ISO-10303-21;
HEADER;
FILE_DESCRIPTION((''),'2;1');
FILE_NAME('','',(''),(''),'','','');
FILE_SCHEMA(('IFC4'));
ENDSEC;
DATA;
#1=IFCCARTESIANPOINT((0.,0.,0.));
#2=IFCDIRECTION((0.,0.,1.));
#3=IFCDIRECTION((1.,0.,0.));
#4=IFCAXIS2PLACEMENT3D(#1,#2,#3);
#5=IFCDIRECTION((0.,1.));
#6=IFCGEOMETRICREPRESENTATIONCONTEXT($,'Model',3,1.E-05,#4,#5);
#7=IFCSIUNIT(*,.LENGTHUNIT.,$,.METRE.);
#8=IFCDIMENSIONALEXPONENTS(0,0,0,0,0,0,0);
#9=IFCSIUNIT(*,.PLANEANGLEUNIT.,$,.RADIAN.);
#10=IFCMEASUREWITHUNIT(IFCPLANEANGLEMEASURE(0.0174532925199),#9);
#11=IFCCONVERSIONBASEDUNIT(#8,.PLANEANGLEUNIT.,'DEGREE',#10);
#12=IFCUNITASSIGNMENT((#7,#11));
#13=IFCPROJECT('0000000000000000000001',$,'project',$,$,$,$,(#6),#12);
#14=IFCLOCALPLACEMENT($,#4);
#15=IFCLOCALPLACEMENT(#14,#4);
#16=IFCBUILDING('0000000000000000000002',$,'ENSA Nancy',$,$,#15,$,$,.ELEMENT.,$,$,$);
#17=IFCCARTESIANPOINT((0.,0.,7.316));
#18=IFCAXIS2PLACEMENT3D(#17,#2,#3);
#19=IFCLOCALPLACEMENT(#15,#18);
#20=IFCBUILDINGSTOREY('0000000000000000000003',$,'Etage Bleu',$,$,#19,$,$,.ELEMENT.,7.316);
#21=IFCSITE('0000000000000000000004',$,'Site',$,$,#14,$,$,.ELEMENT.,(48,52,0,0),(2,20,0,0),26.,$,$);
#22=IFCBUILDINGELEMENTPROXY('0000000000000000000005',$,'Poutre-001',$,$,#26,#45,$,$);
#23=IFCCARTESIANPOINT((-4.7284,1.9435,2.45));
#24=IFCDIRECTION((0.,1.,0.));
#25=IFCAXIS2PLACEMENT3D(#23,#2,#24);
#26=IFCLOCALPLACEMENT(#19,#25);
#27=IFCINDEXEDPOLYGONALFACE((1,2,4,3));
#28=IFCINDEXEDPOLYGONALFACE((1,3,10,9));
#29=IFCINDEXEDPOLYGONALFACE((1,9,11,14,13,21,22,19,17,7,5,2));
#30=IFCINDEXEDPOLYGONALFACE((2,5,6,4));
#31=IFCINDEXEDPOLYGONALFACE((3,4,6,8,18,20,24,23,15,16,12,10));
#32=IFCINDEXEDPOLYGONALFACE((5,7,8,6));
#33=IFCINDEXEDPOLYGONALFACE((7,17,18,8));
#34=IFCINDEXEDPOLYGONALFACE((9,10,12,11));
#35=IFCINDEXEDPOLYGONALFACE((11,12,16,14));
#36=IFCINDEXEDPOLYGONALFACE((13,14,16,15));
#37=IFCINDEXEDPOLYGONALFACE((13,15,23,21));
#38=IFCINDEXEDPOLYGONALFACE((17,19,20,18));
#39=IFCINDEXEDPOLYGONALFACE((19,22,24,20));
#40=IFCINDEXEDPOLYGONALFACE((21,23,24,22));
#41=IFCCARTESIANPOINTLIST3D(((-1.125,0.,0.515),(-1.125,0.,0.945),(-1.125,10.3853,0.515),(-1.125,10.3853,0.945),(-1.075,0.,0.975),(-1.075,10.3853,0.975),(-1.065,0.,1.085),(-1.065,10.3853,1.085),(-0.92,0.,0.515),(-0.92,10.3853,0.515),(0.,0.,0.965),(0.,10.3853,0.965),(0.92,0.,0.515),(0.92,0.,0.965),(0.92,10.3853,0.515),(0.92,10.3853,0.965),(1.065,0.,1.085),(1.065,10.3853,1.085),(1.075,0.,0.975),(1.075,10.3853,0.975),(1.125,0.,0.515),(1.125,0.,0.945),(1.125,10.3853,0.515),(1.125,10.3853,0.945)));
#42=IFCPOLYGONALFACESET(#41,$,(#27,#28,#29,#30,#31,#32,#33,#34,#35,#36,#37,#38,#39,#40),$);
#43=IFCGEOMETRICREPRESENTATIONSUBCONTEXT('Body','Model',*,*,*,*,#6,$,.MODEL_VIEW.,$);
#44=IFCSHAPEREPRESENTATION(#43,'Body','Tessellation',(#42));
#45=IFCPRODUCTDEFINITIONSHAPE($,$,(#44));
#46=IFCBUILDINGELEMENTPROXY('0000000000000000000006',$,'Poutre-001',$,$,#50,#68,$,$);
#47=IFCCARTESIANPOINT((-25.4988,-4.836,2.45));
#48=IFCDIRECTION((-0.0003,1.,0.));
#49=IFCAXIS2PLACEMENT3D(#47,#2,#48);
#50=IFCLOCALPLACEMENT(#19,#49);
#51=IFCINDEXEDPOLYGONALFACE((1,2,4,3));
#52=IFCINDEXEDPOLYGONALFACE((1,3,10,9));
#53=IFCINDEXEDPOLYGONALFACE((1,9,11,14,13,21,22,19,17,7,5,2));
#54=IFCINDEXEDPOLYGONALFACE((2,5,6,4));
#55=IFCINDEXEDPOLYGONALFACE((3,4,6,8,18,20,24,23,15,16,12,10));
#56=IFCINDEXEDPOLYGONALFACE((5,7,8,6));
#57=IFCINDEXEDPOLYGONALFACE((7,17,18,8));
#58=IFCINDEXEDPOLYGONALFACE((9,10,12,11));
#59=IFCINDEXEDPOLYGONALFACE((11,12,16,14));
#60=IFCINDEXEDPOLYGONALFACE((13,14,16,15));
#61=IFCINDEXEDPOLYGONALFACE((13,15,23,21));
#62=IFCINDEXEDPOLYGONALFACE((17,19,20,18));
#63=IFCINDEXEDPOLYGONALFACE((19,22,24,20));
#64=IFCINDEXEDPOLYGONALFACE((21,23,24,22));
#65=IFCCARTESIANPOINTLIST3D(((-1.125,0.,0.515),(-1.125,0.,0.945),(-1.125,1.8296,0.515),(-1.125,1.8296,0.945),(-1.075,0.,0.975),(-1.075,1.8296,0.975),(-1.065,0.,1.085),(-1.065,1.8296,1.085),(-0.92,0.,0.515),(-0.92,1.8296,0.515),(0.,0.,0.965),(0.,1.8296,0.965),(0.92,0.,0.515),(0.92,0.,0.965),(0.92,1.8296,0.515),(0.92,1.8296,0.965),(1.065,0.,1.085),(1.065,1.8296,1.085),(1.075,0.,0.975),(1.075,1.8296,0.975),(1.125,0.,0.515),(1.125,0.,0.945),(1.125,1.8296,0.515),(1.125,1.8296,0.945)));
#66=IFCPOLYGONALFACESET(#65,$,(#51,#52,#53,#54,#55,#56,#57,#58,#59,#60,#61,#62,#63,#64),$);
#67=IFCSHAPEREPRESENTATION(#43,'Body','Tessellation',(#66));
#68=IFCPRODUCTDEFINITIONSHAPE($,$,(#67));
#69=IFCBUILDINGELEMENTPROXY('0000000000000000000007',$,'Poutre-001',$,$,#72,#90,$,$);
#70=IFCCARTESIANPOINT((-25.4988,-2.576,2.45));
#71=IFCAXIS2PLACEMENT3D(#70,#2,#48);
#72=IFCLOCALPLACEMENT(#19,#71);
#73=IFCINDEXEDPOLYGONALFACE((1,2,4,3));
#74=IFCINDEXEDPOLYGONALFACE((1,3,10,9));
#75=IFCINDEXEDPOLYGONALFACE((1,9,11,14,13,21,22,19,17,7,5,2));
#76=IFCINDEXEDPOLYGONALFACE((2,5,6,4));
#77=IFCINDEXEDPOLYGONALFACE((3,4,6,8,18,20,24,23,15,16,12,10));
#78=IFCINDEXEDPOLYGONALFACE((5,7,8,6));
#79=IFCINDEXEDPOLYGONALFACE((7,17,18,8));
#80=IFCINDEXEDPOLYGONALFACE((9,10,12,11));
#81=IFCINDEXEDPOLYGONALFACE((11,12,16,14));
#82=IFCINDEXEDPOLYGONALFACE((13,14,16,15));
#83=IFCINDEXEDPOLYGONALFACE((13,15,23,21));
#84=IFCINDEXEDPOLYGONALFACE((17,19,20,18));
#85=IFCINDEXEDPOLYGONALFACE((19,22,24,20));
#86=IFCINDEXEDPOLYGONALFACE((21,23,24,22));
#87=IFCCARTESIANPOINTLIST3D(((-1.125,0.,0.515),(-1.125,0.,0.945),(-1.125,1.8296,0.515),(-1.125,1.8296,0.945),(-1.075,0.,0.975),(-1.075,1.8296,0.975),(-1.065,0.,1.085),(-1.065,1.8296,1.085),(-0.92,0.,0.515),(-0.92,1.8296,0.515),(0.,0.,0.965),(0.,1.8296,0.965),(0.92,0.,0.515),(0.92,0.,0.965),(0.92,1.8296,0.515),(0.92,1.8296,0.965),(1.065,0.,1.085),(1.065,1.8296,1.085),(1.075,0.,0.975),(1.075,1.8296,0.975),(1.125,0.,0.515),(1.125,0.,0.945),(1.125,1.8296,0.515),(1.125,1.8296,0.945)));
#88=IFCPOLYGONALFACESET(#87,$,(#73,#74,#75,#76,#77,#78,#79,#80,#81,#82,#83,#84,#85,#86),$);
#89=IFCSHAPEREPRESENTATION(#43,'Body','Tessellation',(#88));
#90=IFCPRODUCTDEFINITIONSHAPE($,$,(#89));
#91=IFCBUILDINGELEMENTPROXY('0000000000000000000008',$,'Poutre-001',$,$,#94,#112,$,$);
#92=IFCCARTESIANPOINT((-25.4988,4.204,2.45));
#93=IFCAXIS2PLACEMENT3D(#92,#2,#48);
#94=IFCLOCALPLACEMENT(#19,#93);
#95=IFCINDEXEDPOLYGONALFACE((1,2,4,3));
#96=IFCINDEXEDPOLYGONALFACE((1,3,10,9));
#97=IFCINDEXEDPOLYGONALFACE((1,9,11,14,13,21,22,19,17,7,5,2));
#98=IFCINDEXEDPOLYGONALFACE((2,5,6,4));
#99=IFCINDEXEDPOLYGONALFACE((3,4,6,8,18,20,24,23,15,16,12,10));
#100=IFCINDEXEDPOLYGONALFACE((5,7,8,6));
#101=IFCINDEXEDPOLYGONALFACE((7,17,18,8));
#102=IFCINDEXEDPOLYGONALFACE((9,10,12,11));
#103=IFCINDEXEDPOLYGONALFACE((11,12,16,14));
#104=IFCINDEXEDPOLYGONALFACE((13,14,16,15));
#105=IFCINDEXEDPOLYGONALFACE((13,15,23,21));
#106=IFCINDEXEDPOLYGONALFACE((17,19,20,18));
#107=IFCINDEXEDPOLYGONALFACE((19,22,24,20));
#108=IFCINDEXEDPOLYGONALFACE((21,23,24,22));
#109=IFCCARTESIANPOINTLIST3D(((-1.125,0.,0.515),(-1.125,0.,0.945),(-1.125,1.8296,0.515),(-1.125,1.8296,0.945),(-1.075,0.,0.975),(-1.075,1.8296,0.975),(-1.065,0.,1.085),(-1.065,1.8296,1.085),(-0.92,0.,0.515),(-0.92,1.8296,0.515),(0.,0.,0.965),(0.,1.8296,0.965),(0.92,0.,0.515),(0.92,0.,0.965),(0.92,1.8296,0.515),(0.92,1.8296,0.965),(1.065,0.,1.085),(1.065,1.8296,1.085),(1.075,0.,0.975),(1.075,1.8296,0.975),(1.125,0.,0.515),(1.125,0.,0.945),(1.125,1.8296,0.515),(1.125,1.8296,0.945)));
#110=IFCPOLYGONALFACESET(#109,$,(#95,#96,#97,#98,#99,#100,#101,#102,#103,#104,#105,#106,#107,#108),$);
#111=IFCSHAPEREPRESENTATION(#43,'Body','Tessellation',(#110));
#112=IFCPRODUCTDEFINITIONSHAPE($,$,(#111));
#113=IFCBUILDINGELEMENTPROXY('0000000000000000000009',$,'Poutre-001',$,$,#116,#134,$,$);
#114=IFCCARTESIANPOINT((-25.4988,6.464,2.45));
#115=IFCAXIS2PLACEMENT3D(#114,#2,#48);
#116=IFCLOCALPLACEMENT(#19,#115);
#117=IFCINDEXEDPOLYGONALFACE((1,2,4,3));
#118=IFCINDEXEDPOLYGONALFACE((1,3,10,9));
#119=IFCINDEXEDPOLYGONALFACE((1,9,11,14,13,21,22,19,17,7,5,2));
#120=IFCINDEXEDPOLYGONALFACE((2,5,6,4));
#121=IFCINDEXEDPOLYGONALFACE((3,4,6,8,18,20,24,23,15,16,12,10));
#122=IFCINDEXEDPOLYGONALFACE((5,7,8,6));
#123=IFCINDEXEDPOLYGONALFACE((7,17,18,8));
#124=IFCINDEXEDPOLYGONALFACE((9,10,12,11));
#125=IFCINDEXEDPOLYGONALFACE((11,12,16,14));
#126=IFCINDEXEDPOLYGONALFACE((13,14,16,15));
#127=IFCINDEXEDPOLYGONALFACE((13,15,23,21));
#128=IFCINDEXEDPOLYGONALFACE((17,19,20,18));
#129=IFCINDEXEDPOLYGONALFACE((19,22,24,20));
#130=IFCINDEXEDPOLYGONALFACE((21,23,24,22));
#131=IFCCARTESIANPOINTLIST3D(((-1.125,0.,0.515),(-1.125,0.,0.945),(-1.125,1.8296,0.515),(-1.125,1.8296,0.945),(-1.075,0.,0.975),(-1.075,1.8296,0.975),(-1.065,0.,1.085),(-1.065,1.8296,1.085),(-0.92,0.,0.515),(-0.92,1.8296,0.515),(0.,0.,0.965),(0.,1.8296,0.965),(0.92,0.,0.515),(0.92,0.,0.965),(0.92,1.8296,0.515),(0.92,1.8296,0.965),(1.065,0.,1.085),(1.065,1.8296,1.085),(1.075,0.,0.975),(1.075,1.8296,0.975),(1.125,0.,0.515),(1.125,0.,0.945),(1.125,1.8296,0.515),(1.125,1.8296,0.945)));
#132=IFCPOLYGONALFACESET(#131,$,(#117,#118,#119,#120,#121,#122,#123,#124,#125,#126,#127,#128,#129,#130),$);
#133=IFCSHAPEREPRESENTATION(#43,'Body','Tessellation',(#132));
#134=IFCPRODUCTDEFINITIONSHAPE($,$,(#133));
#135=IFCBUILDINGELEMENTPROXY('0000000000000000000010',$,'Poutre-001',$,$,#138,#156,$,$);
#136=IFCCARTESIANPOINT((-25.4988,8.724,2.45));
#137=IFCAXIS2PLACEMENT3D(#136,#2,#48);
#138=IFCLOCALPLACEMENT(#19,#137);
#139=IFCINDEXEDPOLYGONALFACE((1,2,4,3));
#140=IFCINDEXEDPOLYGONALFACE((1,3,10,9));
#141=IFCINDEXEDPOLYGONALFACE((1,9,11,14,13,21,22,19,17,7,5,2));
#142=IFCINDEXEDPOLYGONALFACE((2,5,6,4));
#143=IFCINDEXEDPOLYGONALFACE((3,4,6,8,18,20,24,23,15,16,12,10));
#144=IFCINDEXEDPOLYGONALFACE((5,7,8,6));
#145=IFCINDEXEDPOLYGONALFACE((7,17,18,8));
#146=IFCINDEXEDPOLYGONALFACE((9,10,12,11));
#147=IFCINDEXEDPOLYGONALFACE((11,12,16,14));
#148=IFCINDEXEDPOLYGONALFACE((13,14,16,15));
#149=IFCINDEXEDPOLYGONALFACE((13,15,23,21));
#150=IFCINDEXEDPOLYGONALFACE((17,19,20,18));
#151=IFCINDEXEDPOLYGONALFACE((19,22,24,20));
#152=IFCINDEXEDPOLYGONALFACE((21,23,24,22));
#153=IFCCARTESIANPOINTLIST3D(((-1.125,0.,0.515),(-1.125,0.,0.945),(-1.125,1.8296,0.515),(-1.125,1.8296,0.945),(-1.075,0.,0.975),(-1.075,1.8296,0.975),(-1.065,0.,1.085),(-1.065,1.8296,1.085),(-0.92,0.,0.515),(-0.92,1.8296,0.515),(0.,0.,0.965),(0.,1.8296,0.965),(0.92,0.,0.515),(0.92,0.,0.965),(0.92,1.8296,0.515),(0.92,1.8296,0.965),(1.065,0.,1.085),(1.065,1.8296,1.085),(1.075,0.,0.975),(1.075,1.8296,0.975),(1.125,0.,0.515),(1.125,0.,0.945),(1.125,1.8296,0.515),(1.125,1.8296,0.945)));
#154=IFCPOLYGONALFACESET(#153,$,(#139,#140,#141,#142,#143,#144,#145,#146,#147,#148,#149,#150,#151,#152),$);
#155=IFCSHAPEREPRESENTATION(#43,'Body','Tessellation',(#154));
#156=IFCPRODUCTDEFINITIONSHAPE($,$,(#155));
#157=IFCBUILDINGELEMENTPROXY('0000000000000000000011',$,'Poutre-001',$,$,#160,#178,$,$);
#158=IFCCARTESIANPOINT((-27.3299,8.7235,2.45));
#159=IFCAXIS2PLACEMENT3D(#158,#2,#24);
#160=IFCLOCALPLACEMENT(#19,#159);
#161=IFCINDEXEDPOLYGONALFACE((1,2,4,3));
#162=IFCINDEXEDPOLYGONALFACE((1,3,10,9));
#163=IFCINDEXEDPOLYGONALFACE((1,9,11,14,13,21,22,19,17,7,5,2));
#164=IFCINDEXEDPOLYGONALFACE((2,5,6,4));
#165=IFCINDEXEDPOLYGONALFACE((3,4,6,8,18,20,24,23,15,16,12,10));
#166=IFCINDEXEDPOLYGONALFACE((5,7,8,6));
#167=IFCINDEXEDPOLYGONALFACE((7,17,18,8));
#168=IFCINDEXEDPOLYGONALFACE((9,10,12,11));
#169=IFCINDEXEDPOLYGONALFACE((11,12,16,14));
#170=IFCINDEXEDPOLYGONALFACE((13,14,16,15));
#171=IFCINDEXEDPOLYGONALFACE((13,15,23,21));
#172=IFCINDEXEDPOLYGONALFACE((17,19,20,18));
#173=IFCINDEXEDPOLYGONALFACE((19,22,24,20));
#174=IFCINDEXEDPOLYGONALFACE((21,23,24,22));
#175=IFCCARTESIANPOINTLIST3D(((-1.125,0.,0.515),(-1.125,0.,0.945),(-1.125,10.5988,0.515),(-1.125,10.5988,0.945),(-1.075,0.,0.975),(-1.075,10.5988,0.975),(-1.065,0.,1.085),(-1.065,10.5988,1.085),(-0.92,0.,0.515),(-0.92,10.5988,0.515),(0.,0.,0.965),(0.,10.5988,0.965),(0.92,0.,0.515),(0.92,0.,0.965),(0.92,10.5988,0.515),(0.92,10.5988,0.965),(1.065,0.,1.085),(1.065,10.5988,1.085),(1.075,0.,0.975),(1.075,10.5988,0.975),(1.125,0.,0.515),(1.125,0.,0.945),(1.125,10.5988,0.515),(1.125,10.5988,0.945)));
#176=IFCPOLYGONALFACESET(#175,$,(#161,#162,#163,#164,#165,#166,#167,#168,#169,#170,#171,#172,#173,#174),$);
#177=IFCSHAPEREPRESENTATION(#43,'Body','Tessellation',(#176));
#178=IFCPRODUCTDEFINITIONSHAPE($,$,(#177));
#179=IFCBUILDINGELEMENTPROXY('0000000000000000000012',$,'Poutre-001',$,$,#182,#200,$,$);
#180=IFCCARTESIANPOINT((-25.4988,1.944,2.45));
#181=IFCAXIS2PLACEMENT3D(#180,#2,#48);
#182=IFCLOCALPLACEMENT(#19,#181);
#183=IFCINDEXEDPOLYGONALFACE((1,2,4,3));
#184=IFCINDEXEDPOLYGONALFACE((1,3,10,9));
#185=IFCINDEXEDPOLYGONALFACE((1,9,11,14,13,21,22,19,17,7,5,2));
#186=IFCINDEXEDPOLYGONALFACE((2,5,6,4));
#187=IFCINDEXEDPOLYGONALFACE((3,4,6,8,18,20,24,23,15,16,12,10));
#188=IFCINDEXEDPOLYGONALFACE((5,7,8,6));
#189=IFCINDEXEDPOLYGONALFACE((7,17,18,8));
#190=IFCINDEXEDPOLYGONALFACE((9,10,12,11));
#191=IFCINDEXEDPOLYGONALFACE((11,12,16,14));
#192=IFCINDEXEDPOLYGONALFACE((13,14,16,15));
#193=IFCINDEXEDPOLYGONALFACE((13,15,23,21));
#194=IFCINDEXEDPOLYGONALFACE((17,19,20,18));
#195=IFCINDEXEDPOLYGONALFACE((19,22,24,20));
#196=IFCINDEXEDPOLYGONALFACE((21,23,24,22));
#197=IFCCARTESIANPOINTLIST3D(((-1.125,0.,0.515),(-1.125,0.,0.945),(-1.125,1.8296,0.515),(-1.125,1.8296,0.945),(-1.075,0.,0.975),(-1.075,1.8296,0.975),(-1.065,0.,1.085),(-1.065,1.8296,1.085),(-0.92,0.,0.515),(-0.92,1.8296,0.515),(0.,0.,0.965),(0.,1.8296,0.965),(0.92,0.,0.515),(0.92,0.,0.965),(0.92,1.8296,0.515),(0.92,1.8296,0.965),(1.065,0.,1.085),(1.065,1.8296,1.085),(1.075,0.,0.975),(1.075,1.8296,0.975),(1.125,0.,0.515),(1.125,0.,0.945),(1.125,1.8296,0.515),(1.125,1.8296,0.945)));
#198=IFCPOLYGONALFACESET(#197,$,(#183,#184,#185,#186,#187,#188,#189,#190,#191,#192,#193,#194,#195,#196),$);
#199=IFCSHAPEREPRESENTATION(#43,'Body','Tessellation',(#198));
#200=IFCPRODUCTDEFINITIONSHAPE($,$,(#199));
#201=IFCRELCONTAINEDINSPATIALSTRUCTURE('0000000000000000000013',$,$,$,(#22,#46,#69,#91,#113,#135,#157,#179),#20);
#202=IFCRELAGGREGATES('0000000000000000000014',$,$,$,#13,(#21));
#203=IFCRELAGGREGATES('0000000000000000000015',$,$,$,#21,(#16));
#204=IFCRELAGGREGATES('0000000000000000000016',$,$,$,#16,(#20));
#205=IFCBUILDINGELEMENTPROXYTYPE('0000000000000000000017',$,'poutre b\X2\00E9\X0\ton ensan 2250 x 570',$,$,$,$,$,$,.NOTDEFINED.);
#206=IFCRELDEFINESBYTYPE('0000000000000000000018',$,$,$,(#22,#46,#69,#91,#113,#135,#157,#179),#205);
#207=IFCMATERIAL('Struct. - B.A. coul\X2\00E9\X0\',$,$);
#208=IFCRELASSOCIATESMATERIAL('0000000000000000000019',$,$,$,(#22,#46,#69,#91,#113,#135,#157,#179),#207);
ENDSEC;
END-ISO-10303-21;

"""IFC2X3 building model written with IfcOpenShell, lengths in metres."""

from ifc_helpers import new_model, entity, si_unit, converted_unit, direction, frame, origin_with_axes, place, context, subcontext, project, spatial, polyline, outline, extrude, material, type_object, element, save


model = new_model("IFC2X3")

# Units and contexts
model_context = context("Model", 3, precision=1e-05, world=origin_with_axes(), true_north=direction((0.0, 1.0)))
body_context = subcontext(model_context, "Body", "Model", "MODEL_VIEW")
ifc_project = project(units=[si_unit("LENGTHUNIT", "METRE"), converted_unit("PLANEANGLEUNIT", "DEGREE", entity("IfcPlaneAngleMeasure", 0.0174532925199), si_unit("PLANEANGLEUNIT", "RADIAN"), dimensions=[0, 0, 0, 0, 0, 0, 0])], contexts=[model_context])

# Site, building, storey
site_placement = place(None, origin_with_axes())
site = spatial("IfcSite", under=ifc_project, at=site_placement, Name="Site", CompositionType="ELEMENT", RefLatitude=(48, 52, 0, 0), RefLongitude=(2, 20, 0, 0), RefElevation=26.0)
building_placement = place(site_placement, origin_with_axes())
building = spatial("IfcBuilding", under=site, at=building_placement, Name="ENSA Nancy", CompositionType="ELEMENT")
storey_placement = place(building_placement, frame((0.0, 0.0, 7.316), z_axis=(0.0, 0.0, 1.0), x_axis=(1.0, 0.0, 0.0)))
storey = spatial("IfcBuildingStorey", under=building, at=storey_placement, Name="Etage Bleu", CompositionType="ELEMENT", Elevation=7.316)

# Building element proxies
ifc_material_1 = material(Name="Struct. - B.A. coulé")
building_element_proxy_type_1 = type_object("IfcBuildingElementProxyType", Name="poutre béton ensan 2250 x 570", PredefinedType="NOTDEFINED")
proxy_1_placement = place(storey_placement, frame((-4.7284, 1.9435, 2.45), z_axis=(0.0, 0.0, 1.0), x_axis=(0.0, 1.0, 0.0)))
element("IfcBuildingElementProxy", 1, at=proxy_1_placement, inside=storey, type_object=building_element_proxy_type_1, material=ifc_material_1, Name="Poutre-001", context=body_context, shape_type="SweptSolid", body=[
    extrude(outline(polyline([(-1.065, 1.085), (-1.075, 0.975), (-1.125, 0.945), (-1.125, 0.515), (-0.92, 0.515), (0.0, 0.965), (0.92, 0.965), (0.92, 0.515), (1.125, 0.515), (1.125, 0.945), (1.075, 0.975), (1.065, 1.085), (-1.065, 1.085)])), frame((0.0, 10.3853, 0.0), z_axis=(0.0, -1.0, 0.0), x_axis=(1.0, 0.0, 0.0)), (0.0, 0.0, 1.0), 10.3853),
])
for number, where, z_axis, x_axis, name in (
    (2, (-25.4988, -4.836, 2.45), (0.0, 0.0, 1.0), (-0.0003, 1.0, 0.0), "Poutre-001"),
    (3, (-25.4988, -2.576, 2.45), (0.0, 0.0, 1.0), (-0.0003, 1.0, 0.0), "Poutre-001"),
    (4, (-25.4988, 4.204, 2.45), (0.0, 0.0, 1.0), (-0.0003, 1.0, 0.0), "Poutre-001"),
    (5, (-25.4988, 6.464, 2.45), (0.0, 0.0, 1.0), (-0.0003, 1.0, 0.0), "Poutre-001"),
    (6, (-25.4988, 8.724, 2.45), (0.0, 0.0, 1.0), (-0.0003, 1.0, 0.0), "Poutre-001"),
):
    element("IfcBuildingElementProxy", number, at=place(storey_placement, frame(where, z_axis=z_axis, x_axis=x_axis)), inside=storey, type_object=building_element_proxy_type_1, material=ifc_material_1, Name=name, context=body_context, shape_type="SweptSolid", body=[
        extrude(outline(polyline([(-1.065, 1.085), (-1.075, 0.975), (-1.125, 0.945), (-1.125, 0.515), (-0.92, 0.515), (0.0, 0.965), (0.92, 0.965), (0.92, 0.515), (1.125, 0.515), (1.125, 0.945), (1.075, 0.975), (1.065, 1.085), (-1.065, 1.085)])), frame((0.0, 1.8296, 0.0), z_axis=(0.0, -1.0, 0.0), x_axis=(1.0, 0.0, 0.0)), (0.0, 0.0, 1.0), 1.8296),
    ])
proxy_2_placement = place(storey_placement, frame((-27.3299, 8.7235, 2.45), z_axis=(0.0, 0.0, 1.0), x_axis=(0.0, 1.0, 0.0)))
element("IfcBuildingElementProxy", 7, at=proxy_2_placement, inside=storey, type_object=building_element_proxy_type_1, material=ifc_material_1, Name="Poutre-001", context=body_context, shape_type="SweptSolid", body=[
    extrude(outline(polyline([(-1.065, 1.085), (-1.075, 0.975), (-1.125, 0.945), (-1.125, 0.515), (-0.92, 0.515), (0.0, 0.965), (0.92, 0.965), (0.92, 0.515), (1.125, 0.515), (1.125, 0.945), (1.075, 0.975), (1.065, 1.085), (-1.065, 1.085)])), frame((0.0, 10.5988, 0.0), z_axis=(0.0, -1.0, 0.0), x_axis=(1.0, 0.0, 0.0)), (0.0, 0.0, 1.0), 10.5988),
])
proxy_3_placement = place(storey_placement, frame((-25.4988, 1.944, 2.45), z_axis=(0.0, 0.0, 1.0), x_axis=(-0.0003, 1.0, 0.0)))
element("IfcBuildingElementProxy", 8, at=proxy_3_placement, inside=storey, type_object=building_element_proxy_type_1, material=ifc_material_1, Name="Poutre-001", context=body_context, shape_type="SweptSolid", body=[
    extrude(outline(polyline([(-1.065, 1.085), (-1.075, 0.975), (-1.125, 0.945), (-1.125, 0.515), (-0.92, 0.515), (0.0, 0.965), (0.92, 0.965), (0.92, 0.515), (1.125, 0.515), (1.125, 0.945), (1.075, 0.975), (1.065, 1.085), (-1.065, 1.085)])), frame((0.0, 1.8296, 0.0), z_axis=(0.0, -1.0, 0.0), x_axis=(1.0, 0.0, 0.0)), (0.0, 0.0, 1.0), 1.8296),
])

save(model, "model.ifc")
